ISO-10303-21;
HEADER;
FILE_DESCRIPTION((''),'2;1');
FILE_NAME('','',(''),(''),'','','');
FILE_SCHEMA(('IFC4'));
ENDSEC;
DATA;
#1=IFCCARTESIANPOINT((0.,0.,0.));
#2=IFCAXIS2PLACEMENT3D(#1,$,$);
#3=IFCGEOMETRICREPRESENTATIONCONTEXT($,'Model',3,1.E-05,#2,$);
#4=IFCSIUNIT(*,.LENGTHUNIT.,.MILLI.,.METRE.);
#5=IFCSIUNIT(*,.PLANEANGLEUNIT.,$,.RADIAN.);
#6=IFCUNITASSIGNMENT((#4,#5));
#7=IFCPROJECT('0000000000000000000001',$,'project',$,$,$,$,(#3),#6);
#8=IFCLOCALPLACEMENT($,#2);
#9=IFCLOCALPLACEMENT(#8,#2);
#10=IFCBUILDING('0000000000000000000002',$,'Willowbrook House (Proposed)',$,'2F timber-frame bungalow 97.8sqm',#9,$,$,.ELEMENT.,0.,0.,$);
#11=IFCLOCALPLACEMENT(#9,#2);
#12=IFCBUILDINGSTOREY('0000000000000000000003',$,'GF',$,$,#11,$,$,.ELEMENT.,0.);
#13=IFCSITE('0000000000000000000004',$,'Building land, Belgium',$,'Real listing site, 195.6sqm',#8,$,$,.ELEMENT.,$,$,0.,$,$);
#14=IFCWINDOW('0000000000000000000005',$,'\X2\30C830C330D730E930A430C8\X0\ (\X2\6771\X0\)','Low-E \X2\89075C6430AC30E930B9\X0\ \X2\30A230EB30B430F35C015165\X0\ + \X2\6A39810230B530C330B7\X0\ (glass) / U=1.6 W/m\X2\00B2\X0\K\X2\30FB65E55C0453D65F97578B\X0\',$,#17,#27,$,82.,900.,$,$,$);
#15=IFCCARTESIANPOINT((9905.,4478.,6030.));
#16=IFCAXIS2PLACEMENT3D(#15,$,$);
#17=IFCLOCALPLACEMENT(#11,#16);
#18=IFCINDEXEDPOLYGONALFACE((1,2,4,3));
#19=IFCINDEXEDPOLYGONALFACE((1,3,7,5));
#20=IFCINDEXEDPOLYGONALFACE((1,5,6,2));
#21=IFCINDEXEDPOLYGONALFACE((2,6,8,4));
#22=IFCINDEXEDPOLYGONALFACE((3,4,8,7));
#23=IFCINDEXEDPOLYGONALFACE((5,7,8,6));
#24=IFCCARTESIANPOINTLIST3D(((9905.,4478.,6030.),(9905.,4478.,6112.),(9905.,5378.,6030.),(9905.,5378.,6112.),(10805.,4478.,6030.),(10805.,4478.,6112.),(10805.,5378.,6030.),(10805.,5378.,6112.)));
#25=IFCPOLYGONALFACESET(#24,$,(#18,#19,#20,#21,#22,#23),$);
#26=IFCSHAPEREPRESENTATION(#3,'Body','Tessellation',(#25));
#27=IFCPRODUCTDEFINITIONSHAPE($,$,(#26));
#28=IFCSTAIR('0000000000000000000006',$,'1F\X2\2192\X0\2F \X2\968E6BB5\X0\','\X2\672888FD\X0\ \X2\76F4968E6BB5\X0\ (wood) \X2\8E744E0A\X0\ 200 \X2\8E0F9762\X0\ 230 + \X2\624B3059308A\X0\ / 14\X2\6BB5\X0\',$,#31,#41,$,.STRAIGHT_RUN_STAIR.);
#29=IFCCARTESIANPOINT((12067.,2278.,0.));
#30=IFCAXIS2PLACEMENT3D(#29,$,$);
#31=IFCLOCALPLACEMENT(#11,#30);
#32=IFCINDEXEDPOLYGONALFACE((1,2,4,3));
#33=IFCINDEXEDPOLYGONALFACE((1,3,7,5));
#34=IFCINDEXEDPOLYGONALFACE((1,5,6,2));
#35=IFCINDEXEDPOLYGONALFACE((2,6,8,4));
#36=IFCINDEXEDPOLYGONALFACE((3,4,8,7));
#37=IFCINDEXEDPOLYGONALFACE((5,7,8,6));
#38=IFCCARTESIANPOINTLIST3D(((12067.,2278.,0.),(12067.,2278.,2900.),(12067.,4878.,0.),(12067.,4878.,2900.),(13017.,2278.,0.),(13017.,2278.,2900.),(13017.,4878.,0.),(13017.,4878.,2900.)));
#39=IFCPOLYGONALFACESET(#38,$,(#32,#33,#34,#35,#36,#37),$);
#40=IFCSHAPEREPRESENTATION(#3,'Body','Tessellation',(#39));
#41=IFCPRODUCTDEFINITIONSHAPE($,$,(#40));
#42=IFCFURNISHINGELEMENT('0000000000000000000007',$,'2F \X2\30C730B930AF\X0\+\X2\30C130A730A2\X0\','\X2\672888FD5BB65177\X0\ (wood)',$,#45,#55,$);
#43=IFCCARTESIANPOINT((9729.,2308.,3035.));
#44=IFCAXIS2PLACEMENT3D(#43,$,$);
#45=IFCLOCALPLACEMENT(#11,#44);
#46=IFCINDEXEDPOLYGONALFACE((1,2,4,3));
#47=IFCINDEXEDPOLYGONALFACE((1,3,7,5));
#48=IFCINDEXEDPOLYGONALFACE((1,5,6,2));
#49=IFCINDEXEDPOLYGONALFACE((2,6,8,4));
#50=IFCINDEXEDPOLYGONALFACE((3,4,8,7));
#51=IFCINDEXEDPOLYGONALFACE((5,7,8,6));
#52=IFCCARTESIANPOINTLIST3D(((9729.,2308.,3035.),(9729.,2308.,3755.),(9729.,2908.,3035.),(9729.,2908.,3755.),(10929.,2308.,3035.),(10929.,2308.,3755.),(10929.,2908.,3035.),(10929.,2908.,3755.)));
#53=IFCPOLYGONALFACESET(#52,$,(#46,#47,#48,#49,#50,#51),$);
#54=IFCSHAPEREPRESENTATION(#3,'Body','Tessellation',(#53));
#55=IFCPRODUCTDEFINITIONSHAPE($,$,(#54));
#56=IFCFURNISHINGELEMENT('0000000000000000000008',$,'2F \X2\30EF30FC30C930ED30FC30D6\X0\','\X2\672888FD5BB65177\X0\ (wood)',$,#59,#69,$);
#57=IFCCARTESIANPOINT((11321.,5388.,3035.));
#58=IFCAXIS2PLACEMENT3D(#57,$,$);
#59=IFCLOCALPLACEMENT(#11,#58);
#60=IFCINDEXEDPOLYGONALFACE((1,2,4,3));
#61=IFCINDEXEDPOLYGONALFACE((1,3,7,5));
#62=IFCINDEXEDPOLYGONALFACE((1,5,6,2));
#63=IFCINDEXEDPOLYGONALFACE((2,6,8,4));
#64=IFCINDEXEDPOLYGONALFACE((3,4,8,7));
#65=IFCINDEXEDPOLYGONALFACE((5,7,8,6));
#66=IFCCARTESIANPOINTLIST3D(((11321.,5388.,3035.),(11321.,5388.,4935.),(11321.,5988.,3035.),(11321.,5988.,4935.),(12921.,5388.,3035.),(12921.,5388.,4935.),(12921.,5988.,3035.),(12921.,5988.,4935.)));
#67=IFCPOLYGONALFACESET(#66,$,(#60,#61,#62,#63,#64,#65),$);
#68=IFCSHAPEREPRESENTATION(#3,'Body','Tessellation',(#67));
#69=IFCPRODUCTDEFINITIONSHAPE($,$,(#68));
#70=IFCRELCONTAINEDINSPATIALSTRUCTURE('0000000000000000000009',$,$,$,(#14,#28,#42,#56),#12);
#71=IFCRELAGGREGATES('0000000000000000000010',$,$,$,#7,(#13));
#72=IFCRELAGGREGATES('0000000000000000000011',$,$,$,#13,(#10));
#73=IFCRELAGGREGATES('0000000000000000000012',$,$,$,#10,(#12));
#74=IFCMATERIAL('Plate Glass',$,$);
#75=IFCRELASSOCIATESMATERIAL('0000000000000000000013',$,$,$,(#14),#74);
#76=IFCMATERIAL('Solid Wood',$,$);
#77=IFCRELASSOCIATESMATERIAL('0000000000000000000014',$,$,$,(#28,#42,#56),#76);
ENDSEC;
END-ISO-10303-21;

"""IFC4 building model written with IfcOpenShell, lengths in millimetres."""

from ifc_helpers import new_model, si_unit, frame, frame_2d, origin, place, context, project, spatial, rectangle, extrude, material, element, save


model = new_model("IFC4")

# Units and contexts
model_context = context("Model", 3, precision=1e-05, world=origin())
ifc_project = project(units=[si_unit("LENGTHUNIT", "METRE", prefix="MILLI"), si_unit("PLANEANGLEUNIT", "RADIAN")], contexts=[model_context])

# Site, building, storey
site_placement = place(None, origin())
site = spatial("IfcSite", under=ifc_project, at=site_placement, Name="Building land, Belgium", ObjectType="Real listing site, 195.6sqm", CompositionType="ELEMENT", RefElevation=0.0)
building_placement = place(site_placement, origin())
building = spatial("IfcBuilding", under=site, at=building_placement, Name="Willowbrook House (Proposed)", ObjectType="2F timber-frame bungalow 97.8sqm", CompositionType="ELEMENT", ElevationOfRefHeight=0.0, ElevationOfTerrain=0.0)
storey_placement = place(building_placement, origin())
storey = spatial("IfcBuildingStorey", under=building, at=storey_placement, Name="GF", CompositionType="ELEMENT", Elevation=0.0)

# Shared definitions
ifc_material_1 = material(Name="Solid Wood")

# Shared definitions
ifc_material_2 = material(Name="Plate Glass")

# Window
window_1_placement = place(storey_placement, frame((9905.0, 4478.0, 6030.0)))
element("IfcWindow", 1, at=window_1_placement, inside=storey, material=ifc_material_2, Name="トップライト (東)", Description="Low-E 複層ガラス アルゴン封入 + 樹脂サッシ (glass) / U=1.6 W/m²K・日射取得型", OverallHeight=82.0, OverallWidth=900.0, context=model_context, shape_type="SweptSolid", body=[
    extrude(rectangle(XDim=900.0, YDim=900.0, at=frame_2d((450.0, 450.0))), frame((9905.0, 4478.0, 6030.0)), (0.0, 0.0, 1.0), 82.0),
])

# Stair
stair_placement = place(storey_placement, frame((12067.0, 2278.0, 0.0)))
element("IfcStair", 2, at=stair_placement, inside=storey, material=ifc_material_1, Name="1F→2F 階段", Description="木製 直階段 (wood) 蹴上 200 踏面 230 + 手すり / 14段", PredefinedType="STRAIGHT_RUN_STAIR", context=model_context, shape_type="SweptSolid", body=[
    extrude(rectangle(XDim=950.0, YDim=2600.0, at=frame_2d((475.0, 1300.0))), frame((12067.0, 2278.0, 0.0)), (0.0, 0.0, 1.0), 2900.0),
])

# Furnishing elements
furnishing_1_placement = place(storey_placement, frame((9729.0, 2308.0, 3035.0)))
element("IfcFurnishingElement", 3, at=furnishing_1_placement, inside=storey, material=ifc_material_1, Name="2F デスク+チェア", Description="木製家具 (wood)", context=model_context, shape_type="SweptSolid", body=[
    extrude(rectangle(XDim=1200.0, YDim=600.0, at=frame_2d((600.0, 300.0))), frame((9729.0, 2308.0, 3035.0)), (0.0, 0.0, 1.0), 720.0),
])
furnishing_2_placement = place(storey_placement, frame((11321.0, 5388.0, 3035.0)))
element("IfcFurnishingElement", 4, at=furnishing_2_placement, inside=storey, material=ifc_material_1, Name="2F ワードローブ", Description="木製家具 (wood)", context=model_context, shape_type="SweptSolid", body=[
    extrude(rectangle(XDim=1600.0, YDim=600.0, at=frame_2d((800.0, 300.0))), frame((11321.0, 5388.0, 3035.0)), (0.0, 0.0, 1.0), 1900.0),
])

save(model, "model.ifc")
